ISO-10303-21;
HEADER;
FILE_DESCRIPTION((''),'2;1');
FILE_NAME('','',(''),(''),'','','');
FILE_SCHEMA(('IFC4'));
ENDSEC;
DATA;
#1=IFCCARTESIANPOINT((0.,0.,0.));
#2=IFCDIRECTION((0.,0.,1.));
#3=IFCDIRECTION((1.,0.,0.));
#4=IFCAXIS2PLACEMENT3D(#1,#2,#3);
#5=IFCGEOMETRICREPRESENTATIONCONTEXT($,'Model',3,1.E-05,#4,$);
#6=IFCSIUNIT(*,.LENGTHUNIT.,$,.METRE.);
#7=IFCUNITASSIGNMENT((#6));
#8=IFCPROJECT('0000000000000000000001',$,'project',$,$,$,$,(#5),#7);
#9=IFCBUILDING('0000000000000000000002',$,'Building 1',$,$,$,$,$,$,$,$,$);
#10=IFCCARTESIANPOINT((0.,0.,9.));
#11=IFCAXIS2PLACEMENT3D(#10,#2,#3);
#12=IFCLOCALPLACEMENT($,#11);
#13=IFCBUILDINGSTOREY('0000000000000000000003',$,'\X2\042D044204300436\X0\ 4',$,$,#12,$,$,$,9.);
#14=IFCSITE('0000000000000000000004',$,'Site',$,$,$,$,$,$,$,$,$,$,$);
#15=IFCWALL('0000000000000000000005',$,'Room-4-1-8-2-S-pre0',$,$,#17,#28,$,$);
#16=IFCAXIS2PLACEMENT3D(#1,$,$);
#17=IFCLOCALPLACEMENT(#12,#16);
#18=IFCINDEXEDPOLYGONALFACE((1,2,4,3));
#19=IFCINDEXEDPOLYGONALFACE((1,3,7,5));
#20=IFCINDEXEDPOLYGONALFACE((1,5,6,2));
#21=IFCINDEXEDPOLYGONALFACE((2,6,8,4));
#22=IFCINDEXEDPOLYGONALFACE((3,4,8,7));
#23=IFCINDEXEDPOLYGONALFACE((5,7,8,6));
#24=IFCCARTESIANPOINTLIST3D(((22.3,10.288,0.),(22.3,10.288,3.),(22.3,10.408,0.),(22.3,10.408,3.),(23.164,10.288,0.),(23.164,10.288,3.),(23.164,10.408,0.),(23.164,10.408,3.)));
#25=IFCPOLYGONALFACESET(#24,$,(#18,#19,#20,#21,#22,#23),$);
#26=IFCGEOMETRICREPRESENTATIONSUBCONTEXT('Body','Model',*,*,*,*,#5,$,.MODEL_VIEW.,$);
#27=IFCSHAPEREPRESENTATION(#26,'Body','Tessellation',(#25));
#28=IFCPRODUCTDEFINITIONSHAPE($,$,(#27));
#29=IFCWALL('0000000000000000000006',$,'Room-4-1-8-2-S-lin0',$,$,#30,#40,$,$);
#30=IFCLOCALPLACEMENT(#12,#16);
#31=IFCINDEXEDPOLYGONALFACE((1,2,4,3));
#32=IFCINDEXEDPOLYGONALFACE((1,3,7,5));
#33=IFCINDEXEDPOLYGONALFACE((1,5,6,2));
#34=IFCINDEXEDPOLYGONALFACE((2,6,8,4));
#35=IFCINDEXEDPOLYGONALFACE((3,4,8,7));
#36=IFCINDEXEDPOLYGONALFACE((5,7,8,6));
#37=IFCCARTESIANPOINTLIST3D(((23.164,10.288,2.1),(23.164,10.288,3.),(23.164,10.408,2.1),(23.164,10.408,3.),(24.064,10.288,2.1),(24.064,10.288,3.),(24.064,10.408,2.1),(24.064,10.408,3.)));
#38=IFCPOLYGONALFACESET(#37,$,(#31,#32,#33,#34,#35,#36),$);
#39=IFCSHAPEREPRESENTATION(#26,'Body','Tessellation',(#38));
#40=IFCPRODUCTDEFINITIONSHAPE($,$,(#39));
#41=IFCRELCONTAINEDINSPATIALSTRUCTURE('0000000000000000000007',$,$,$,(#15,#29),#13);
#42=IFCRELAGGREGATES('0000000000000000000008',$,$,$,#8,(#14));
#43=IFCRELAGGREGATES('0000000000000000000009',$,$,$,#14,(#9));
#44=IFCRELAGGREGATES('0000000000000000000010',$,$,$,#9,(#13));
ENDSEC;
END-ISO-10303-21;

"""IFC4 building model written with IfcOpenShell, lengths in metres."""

from ifc_helpers import new_model, si_unit, frame, origin_with_axes, place, context, subcontext, project, spatial, indexed_curve, outline, extrude, element, save


model = new_model("IFC4")

# Units and contexts
model_context = context("Model", 3, precision=1e-05, world=origin_with_axes())
body_context = subcontext(model_context, "Body", "Model", "MODEL_VIEW")
ifc_project = project(units=[si_unit("LENGTHUNIT", "METRE")], contexts=[model_context])

# Site, building, storey
site = spatial("IfcSite", under=ifc_project, Name="Site")
building = spatial("IfcBuilding", under=site, Name="Building 1")
storey_placement = place(None, frame((0.0, 0.0, 9.0), z_axis=(0.0, 0.0, 1.0), x_axis=(1.0, 0.0, 0.0)))
storey = spatial("IfcBuildingStorey", under=building, at=storey_placement, Name="Этаж 4", Elevation=9.0)

# Walls
wall_1_placement = place(storey_placement, frame((22.3, 10.288, 0.0), z_axis=(0.0, 0.0, 1.0), x_axis=(1.0, 0.0, 0.0)))
element("IfcWall", 1, at=wall_1_placement, inside=storey, Name="Room-4-1-8-2-S-pre0", context=body_context, shape_type="SweptSolid", body=[
    extrude(outline(indexed_curve([(0.0, 0.0), (0.0, 0.12), (0.864, 0.12), (0.864, 0.0), (0.0, 0.0)], self_intersect=False)), origin_with_axes(), (0.0, 0.0, 1.0), 3.0),
])
wall_2_placement = place(storey_placement, frame((23.164, 10.288, 2.1), z_axis=(0.0, 0.0, 1.0), x_axis=(1.0, 0.0, 0.0)))
element("IfcWall", 2, at=wall_2_placement, inside=storey, Name="Room-4-1-8-2-S-lin0", context=body_context, shape_type="SweptSolid", body=[
    extrude(outline(indexed_curve([(0.0, 0.0), (0.0, 0.12), (0.9, 0.12), (0.9, 0.0), (0.0, 0.0)], self_intersect=False)), origin_with_axes(), (0.0, 0.0, 1.0), 0.9),
])

save(model, "model.ifc")
